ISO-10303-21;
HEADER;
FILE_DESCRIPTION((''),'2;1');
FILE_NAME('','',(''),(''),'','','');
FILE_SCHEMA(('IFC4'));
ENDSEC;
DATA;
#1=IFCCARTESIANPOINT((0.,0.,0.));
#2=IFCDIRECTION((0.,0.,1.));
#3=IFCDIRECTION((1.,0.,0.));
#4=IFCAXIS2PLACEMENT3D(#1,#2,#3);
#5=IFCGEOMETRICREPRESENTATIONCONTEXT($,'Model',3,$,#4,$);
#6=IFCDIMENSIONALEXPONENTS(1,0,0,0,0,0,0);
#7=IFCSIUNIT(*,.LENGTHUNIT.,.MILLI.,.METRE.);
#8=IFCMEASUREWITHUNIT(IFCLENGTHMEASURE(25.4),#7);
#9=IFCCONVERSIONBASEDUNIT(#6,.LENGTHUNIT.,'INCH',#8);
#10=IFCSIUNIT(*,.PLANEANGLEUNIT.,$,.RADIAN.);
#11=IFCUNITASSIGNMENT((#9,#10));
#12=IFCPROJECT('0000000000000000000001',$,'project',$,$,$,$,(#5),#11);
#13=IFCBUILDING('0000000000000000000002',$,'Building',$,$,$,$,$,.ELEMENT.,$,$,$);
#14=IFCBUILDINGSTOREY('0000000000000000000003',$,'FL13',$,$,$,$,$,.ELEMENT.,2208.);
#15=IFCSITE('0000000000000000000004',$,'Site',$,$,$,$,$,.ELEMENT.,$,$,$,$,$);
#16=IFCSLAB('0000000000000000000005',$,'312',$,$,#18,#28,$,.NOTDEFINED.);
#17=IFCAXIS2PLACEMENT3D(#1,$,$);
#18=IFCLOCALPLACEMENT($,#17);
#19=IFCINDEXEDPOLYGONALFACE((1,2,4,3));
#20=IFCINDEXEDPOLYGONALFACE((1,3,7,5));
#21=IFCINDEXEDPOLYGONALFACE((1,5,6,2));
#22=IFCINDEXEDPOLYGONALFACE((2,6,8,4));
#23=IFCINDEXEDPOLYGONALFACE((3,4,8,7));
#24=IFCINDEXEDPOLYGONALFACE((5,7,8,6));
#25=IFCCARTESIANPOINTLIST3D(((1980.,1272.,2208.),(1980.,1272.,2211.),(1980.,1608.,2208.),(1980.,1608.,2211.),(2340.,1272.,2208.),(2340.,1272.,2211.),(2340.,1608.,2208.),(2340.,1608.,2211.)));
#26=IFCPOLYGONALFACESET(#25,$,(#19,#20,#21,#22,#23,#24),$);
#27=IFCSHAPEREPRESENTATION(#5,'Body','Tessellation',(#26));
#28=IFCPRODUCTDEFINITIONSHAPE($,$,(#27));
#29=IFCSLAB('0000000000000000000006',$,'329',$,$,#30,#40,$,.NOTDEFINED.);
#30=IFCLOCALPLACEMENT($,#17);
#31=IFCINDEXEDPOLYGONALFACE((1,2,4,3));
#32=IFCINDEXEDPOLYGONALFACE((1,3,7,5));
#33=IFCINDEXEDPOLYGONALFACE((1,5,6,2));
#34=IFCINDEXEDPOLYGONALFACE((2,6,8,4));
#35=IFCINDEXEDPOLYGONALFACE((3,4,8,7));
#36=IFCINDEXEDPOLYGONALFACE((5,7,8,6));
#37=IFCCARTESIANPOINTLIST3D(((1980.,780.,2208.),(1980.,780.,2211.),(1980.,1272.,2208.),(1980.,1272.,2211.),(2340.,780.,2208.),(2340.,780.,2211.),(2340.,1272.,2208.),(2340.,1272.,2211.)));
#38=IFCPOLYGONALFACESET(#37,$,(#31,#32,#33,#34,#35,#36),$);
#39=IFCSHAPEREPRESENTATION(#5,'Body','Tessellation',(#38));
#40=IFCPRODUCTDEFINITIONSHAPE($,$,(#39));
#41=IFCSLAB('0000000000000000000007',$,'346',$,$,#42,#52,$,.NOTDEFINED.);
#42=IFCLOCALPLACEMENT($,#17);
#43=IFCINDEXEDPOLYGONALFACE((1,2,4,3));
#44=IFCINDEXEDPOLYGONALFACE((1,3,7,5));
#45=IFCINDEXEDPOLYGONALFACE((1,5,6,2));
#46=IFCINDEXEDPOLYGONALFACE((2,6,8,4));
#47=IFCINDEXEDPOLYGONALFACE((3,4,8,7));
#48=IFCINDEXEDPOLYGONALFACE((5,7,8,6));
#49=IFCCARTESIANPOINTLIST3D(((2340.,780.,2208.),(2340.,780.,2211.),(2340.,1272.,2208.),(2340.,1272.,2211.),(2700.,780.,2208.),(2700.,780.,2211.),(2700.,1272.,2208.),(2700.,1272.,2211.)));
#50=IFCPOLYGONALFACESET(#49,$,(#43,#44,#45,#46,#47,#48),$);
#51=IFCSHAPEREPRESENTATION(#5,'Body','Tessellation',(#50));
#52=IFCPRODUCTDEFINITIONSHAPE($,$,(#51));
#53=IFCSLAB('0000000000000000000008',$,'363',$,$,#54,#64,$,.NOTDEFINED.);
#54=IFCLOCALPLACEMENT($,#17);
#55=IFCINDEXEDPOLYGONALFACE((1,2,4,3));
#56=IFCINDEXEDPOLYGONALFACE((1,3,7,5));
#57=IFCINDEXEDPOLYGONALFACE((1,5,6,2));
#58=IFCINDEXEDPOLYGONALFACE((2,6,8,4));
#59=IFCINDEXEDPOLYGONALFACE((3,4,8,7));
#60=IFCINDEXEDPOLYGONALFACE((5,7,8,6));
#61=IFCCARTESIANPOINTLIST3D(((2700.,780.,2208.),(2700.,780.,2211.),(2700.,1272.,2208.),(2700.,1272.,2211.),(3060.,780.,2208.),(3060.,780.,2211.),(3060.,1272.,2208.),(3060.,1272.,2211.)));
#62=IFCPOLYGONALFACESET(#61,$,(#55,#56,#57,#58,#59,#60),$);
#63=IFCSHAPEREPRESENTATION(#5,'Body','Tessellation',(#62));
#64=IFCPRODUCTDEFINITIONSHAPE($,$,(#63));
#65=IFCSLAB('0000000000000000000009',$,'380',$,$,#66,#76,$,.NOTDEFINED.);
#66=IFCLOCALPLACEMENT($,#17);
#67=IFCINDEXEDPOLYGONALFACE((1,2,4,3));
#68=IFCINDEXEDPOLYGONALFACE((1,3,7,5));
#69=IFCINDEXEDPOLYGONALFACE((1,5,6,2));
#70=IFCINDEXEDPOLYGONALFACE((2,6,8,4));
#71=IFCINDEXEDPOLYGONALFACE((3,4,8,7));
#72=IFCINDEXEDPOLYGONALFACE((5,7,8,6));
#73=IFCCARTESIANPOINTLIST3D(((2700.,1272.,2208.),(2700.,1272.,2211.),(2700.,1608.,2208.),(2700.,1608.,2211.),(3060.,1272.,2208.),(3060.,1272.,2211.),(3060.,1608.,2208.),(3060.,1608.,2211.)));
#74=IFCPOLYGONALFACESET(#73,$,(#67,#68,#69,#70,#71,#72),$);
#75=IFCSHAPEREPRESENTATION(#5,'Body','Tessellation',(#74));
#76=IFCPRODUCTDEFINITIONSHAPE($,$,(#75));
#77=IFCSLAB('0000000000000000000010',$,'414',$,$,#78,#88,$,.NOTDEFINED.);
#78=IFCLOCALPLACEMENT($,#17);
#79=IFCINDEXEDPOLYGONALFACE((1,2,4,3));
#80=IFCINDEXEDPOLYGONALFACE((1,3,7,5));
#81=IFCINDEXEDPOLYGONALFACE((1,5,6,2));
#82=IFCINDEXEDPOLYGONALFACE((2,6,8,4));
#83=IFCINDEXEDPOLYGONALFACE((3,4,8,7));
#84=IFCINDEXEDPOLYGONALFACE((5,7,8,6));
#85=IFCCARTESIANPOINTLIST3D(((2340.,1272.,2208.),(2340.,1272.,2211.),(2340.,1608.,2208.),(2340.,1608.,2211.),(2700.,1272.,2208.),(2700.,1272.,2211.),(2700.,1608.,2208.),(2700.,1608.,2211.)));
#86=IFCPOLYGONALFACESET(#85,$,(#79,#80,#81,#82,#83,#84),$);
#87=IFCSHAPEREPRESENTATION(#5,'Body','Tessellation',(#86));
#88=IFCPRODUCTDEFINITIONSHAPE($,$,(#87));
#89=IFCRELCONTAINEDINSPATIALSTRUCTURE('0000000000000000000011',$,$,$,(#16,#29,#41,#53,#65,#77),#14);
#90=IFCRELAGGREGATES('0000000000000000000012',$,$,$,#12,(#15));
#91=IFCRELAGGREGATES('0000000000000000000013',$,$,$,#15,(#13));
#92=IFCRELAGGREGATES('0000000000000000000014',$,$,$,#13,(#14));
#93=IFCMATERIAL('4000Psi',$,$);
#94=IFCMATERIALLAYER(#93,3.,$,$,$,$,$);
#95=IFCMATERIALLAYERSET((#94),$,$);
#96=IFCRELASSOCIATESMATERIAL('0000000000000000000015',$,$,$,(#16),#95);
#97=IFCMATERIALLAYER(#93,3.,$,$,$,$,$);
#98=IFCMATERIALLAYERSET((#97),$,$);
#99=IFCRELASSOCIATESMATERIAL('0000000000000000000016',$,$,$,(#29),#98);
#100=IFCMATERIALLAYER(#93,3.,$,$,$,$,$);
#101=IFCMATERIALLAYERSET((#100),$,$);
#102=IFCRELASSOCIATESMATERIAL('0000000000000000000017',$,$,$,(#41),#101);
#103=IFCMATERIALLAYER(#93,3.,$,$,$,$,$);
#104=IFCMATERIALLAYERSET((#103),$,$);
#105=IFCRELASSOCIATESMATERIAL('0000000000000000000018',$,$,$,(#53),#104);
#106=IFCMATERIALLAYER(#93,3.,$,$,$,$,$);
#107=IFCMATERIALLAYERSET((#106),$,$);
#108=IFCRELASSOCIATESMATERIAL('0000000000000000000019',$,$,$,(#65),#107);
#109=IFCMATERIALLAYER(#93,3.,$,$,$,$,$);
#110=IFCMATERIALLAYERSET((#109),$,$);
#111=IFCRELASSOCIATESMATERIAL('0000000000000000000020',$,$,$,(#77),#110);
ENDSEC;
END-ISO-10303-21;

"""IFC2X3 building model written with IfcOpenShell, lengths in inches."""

from ifc_helpers import new_model, entity, si_unit, converted_unit, frame, origin_with_axes, place, context, project, spatial, polyline, outline, extrude, material, layer, layer_set, layer_usage, element, save


model = new_model("IFC2X3")

# Units and contexts
model_context = context("Model", 3, world=origin_with_axes())
ifc_project = project(units=[converted_unit("LENGTHUNIT", "INCH", entity("IfcLengthMeasure", 25.4), si_unit("LENGTHUNIT", "METRE", prefix="MILLI"), dimensions=[1, 0, 0, 0, 0, 0, 0]), si_unit("PLANEANGLEUNIT", "RADIAN")], contexts=[model_context])

# Site, building, storey
site = spatial("IfcSite", under=ifc_project, Name="Site", CompositionType="ELEMENT")
building = spatial("IfcBuilding", under=site, Name="Building", CompositionType="ELEMENT")
storey = spatial("IfcBuildingStorey", under=building, Name="FL13", CompositionType="ELEMENT", Elevation=2208.0)

# Slabs
ifc_material_1 = material(Name="4000Psi")
ifc_layer_1 = layer(ifc_material_1, 3.0)
ifc_layer_set_1 = layer_set([ifc_layer_1])
ifc_layer_usage_1 = layer_usage(ifc_layer_set_1, "AXIS2", "POSITIVE", -3.0)
slab_1_placement = place(None, frame((1980.0, 1272.0, 2208.0), z_axis=(0.0, 0.0, 1.0), x_axis=(1.0, 0.0, 0.0)))
element("IfcSlab", 1, at=slab_1_placement, inside=storey, material=ifc_layer_usage_1, Name="312", PredefinedType="NOTDEFINED", context=model_context, shape_type="SweptSolid", body=[
    extrude(outline(polyline([(0.0, 0.0), (360.0, 0.0), (360.0, 336.0), (0.0, 336.0), (0.0, 0.0)])), origin_with_axes(), (0.0, 0.0, 1.0), 3.0),
])
ifc_layer_2 = layer(ifc_material_1, 3.0)
ifc_layer_set_2 = layer_set([ifc_layer_2])
ifc_layer_usage_2 = layer_usage(ifc_layer_set_2, "AXIS2", "POSITIVE", -3.0)
slab_2_placement = place(None, frame((1980.0, 780.0, 2208.0), z_axis=(0.0, 0.0, 1.0), x_axis=(1.0, 0.0, 0.0)))
element("IfcSlab", 2, at=slab_2_placement, inside=storey, material=ifc_layer_usage_2, Name="329", PredefinedType="NOTDEFINED", context=model_context, shape_type="SweptSolid", body=[
    extrude(outline(polyline([(0.0, 0.0), (360.0, 0.0), (360.0, 492.0), (0.0, 492.0), (0.0, 0.0)])), origin_with_axes(), (0.0, 0.0, 1.0), 3.0),
])
ifc_layer_3 = layer(ifc_material_1, 3.0)
ifc_layer_set_3 = layer_set([ifc_layer_3])
ifc_layer_usage_3 = layer_usage(ifc_layer_set_3, "AXIS2", "POSITIVE", -3.0)
slab_3_placement = place(None, frame((2340.0, 780.0, 2208.0), z_axis=(0.0, 0.0, 1.0), x_axis=(1.0, 0.0, 0.0)))
element("IfcSlab", 3, at=slab_3_placement, inside=storey, material=ifc_layer_usage_3, Name="346", PredefinedType="NOTDEFINED", context=model_context, shape_type="SweptSolid", body=[
    extrude(outline(polyline([(0.0, 0.0), (360.0, 0.0), (360.0, 492.0), (0.0, 492.0), (0.0, 0.0)])), origin_with_axes(), (0.0, 0.0, 1.0), 3.0),
])
ifc_layer_4 = layer(ifc_material_1, 3.0)
ifc_layer_set_4 = layer_set([ifc_layer_4])
ifc_layer_usage_4 = layer_usage(ifc_layer_set_4, "AXIS2", "POSITIVE", -3.0)
slab_4_placement = place(None, frame((2700.0, 780.0, 2208.0), z_axis=(0.0, 0.0, 1.0), x_axis=(1.0, 0.0, 0.0)))
element("IfcSlab", 4, at=slab_4_placement, inside=storey, material=ifc_layer_usage_4, Name="363", PredefinedType="NOTDEFINED", context=model_context, shape_type="SweptSolid", body=[
    extrude(outline(polyline([(0.0, 0.0), (360.0, 0.0), (360.0, 492.0), (0.0, 492.0), (0.0, 0.0)])), origin_with_axes(), (0.0, 0.0, 1.0), 3.0),
])
ifc_layer_5 = layer(ifc_material_1, 3.0)
ifc_layer_set_5 = layer_set([ifc_layer_5])
ifc_layer_usage_5 = layer_usage(ifc_layer_set_5, "AXIS2", "POSITIVE", -3.0)
slab_5_placement = place(None, frame((2700.0, 1272.0, 2208.0), z_axis=(0.0, 0.0, 1.0), x_axis=(1.0, 0.0, 0.0)))
element("IfcSlab", 5, at=slab_5_placement, inside=storey, material=ifc_layer_usage_5, Name="380", PredefinedType="NOTDEFINED", context=model_context, shape_type="SweptSolid", body=[
    extrude(outline(polyline([(0.0, 0.0), (360.0, 0.0), (360.0, 336.0), (0.0, 336.0), (0.0, 0.0)])), origin_with_axes(), (0.0, 0.0, 1.0), 3.0),
])
ifc_layer_6 = layer(ifc_material_1, 3.0)
ifc_layer_set_6 = layer_set([ifc_layer_6])
ifc_layer_usage_6 = layer_usage(ifc_layer_set_6, "AXIS2", "POSITIVE", -3.0)
slab_6_placement = place(None, frame((2340.0, 1272.0, 2208.0), z_axis=(0.0, 0.0, 1.0), x_axis=(1.0, 0.0, 0.0)))
element("IfcSlab", 6, at=slab_6_placement, inside=storey, material=ifc_layer_usage_6, Name="414", PredefinedType="NOTDEFINED", context=model_context, shape_type="SweptSolid", body=[
    extrude(outline(polyline([(0.0, 0.0), (360.0, 0.0), (360.0, 336.0), (0.0, 336.0), (0.0, 0.0)])), origin_with_axes(), (0.0, 0.0, 1.0), 3.0),
])

save(model, "model.ifc")
